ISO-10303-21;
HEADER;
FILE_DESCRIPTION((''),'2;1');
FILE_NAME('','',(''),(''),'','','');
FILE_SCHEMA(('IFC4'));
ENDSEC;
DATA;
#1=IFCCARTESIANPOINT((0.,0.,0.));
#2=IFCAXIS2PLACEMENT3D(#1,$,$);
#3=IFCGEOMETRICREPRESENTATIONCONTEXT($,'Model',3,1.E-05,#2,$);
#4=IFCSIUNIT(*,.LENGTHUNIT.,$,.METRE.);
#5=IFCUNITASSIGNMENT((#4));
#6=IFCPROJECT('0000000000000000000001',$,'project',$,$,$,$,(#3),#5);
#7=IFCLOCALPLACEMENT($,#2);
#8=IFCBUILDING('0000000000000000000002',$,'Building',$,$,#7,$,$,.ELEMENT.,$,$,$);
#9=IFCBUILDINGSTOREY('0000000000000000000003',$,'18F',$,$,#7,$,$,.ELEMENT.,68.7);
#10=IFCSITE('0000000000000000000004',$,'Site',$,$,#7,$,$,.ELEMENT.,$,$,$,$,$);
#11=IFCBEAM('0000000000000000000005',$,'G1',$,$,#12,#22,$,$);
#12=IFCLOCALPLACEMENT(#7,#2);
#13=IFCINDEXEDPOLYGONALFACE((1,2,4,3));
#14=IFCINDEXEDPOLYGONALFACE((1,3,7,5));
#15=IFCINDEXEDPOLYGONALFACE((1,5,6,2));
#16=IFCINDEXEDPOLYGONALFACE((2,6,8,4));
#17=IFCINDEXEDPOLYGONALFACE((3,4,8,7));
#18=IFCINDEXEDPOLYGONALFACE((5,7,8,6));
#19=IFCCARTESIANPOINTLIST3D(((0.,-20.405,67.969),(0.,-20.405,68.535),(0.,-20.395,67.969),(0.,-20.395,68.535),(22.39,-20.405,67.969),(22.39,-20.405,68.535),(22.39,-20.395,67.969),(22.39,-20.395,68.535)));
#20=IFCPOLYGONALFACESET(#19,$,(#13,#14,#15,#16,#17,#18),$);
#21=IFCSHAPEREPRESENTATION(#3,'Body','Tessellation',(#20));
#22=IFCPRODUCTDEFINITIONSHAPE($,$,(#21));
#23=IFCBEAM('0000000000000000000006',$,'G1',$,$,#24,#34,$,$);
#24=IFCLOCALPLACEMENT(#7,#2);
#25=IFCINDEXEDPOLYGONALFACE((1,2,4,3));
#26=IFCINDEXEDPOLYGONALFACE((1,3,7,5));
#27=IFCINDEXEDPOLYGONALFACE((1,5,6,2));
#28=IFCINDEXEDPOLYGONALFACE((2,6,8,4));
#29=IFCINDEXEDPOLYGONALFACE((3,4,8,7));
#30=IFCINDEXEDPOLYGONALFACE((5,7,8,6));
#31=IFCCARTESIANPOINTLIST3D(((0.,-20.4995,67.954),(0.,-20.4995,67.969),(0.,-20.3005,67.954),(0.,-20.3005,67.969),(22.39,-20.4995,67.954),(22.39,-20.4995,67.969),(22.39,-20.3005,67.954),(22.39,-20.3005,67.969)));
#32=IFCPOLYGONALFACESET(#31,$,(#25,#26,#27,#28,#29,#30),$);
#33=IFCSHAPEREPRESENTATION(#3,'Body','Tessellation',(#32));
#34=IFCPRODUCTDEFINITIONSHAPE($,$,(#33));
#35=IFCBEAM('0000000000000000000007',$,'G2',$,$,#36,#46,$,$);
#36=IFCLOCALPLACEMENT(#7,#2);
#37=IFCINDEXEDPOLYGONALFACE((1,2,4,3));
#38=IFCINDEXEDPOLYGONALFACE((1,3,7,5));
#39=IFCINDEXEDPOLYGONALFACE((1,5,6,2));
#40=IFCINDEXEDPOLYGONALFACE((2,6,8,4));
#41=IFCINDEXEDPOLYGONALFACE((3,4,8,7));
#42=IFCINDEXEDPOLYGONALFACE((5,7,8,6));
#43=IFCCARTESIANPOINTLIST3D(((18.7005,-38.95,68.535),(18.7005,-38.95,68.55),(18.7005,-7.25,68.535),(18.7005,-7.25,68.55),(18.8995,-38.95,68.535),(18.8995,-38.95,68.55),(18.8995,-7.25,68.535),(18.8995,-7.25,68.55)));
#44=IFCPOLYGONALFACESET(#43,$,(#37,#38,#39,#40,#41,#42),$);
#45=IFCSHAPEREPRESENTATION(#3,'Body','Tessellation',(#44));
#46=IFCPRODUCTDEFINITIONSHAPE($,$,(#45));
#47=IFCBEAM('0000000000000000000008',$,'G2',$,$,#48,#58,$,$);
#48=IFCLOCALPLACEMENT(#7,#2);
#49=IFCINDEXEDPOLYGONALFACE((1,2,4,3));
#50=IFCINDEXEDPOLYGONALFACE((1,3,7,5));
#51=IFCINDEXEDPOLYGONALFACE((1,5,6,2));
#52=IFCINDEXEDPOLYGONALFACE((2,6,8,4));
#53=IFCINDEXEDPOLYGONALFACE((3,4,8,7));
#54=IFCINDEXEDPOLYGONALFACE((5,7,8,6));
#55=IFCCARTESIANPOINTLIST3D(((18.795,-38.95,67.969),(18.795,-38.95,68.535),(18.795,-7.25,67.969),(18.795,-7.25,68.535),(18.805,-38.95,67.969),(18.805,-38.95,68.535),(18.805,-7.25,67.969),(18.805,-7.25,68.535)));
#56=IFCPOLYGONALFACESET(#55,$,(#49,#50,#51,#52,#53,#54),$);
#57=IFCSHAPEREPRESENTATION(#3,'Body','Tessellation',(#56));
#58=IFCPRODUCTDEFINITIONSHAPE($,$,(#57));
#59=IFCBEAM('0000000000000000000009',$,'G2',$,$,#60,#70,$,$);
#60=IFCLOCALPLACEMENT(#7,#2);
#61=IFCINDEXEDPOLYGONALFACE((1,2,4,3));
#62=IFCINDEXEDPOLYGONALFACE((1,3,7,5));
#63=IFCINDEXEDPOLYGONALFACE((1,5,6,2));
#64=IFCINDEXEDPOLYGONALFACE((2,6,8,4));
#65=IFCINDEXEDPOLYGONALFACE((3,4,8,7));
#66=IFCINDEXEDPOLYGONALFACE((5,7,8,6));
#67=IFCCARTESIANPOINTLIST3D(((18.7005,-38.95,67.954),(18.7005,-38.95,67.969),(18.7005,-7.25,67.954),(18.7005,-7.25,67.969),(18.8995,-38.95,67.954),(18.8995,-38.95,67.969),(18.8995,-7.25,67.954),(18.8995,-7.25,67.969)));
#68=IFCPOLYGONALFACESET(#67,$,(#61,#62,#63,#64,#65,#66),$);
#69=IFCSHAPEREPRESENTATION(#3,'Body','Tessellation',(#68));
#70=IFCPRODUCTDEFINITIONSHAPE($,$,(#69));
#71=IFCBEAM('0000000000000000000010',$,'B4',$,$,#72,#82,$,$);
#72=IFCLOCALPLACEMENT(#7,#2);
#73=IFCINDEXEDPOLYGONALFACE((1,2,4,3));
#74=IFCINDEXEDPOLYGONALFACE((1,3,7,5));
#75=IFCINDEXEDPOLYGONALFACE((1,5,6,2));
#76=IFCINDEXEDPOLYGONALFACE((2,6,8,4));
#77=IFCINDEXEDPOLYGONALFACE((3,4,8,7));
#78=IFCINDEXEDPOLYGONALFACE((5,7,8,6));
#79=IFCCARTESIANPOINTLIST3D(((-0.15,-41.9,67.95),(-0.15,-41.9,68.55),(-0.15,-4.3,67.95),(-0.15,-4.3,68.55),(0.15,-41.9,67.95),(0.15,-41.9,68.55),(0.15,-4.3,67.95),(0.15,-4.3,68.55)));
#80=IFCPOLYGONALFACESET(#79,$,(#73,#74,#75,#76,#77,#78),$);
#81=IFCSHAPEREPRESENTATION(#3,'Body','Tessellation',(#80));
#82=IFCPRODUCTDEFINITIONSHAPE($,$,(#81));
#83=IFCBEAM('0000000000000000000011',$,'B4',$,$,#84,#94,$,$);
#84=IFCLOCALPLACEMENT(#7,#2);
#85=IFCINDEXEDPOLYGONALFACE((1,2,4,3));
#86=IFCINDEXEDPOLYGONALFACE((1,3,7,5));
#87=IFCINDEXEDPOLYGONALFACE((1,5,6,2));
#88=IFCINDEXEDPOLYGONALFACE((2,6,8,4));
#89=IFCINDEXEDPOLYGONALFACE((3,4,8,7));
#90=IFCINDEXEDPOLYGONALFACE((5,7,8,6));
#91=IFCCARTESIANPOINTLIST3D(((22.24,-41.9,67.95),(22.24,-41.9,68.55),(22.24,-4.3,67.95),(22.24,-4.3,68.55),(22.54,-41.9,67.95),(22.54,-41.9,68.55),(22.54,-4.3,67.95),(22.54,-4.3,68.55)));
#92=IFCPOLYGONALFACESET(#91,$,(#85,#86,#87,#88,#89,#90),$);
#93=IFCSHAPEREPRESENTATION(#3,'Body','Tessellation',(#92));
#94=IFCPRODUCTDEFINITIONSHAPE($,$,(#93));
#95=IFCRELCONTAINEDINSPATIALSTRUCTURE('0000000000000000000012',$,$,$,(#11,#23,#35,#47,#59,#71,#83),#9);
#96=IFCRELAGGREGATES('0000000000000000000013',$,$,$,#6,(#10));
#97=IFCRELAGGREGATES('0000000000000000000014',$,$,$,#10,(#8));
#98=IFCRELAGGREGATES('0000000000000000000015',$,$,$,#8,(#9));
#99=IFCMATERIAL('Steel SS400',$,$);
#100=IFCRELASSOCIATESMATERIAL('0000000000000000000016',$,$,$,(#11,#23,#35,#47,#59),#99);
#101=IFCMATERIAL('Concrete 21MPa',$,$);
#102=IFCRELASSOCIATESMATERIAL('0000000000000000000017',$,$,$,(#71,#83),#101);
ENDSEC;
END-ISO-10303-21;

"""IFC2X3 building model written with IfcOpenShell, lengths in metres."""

from ifc_helpers import new_model, si_unit, frame, origin, origin_2d, place, context, project, spatial, rectangle, extrude, material, element, save


model = new_model("IFC2X3")

# Units and contexts
model_context = context("Model", 3, precision=1e-05, world=origin())
ifc_project = project(units=[si_unit("LENGTHUNIT", "METRE")], contexts=[model_context])

# Site, building, storey
placement = place(None, origin())
site = spatial("IfcSite", under=ifc_project, at=placement, Name="Site", CompositionType="ELEMENT")
building = spatial("IfcBuilding", under=site, at=placement, Name="Building", CompositionType="ELEMENT")
storey = spatial("IfcBuildingStorey", under=building, at=placement, Name="18F", CompositionType="ELEMENT", Elevation=68.7)

# Shared definitions
ifc_material_1 = material(Name="Concrete 21MPa")
ifc_material_2 = material(Name="Steel SS400")

# Beams
beam_1_placement = place(None, frame((11.195, -20.4, 67.969)))
element("IfcBeam", 1, at=beam_1_placement, inside=storey, material=ifc_material_2, Name="G1", context=model_context, shape_type="SweptSolid", body=[
    extrude(rectangle(XDim=22.39, YDim=0.01, at=origin_2d()), origin(), (0.0, 0.0, 1.0), 0.566),
])
beam_2_placement = place(None, frame((11.195, -20.4, 67.954)))
element("IfcBeam", 2, at=beam_2_placement, inside=storey, material=ifc_material_2, Name="G1", context=model_context, shape_type="SweptSolid", body=[
    extrude(rectangle(XDim=22.39, YDim=0.199, at=origin_2d()), origin(), (0.0, 0.0, 1.0), 0.015),
])
beam_3_placement = place(None, frame((18.8, -23.1, 68.535)))
element("IfcBeam", 3, at=beam_3_placement, inside=storey, material=ifc_material_2, Name="G2", context=model_context, shape_type="SweptSolid", body=[
    extrude(rectangle(XDim=0.199, YDim=31.7, at=origin_2d()), origin(), (0.0, 0.0, 1.0), 0.015),
])
beam_4_placement = place(None, frame((18.8, -23.1, 67.969)))
element("IfcBeam", 4, at=beam_4_placement, inside=storey, material=ifc_material_2, Name="G2", context=model_context, shape_type="SweptSolid", body=[
    extrude(rectangle(XDim=0.01, YDim=31.7, at=origin_2d()), origin(), (0.0, 0.0, 1.0), 0.566),
])
beam_5_placement = place(None, frame((18.8, -23.1, 67.954)))
element("IfcBeam", 5, at=beam_5_placement, inside=storey, material=ifc_material_2, Name="G2", context=model_context, shape_type="SweptSolid", body=[
    extrude(rectangle(XDim=0.199, YDim=31.7, at=origin_2d()), origin(), (0.0, 0.0, 1.0), 0.015),
])
for number, where, name in (
    (6, (0.0, -23.1, 67.95), "B4"),
    (7, (22.39, -23.1, 67.95), "B4"),
):
    element("IfcBeam", number, at=place(None, frame(where)), inside=storey, material=ifc_material_1, Name=name, context=model_context, shape_type="SweptSolid", body=[
        extrude(rectangle(XDim=0.3, YDim=37.6, at=origin_2d()), origin(), (0.0, 0.0, 1.0), 0.6),
    ])

save(model, "model.ifc")
